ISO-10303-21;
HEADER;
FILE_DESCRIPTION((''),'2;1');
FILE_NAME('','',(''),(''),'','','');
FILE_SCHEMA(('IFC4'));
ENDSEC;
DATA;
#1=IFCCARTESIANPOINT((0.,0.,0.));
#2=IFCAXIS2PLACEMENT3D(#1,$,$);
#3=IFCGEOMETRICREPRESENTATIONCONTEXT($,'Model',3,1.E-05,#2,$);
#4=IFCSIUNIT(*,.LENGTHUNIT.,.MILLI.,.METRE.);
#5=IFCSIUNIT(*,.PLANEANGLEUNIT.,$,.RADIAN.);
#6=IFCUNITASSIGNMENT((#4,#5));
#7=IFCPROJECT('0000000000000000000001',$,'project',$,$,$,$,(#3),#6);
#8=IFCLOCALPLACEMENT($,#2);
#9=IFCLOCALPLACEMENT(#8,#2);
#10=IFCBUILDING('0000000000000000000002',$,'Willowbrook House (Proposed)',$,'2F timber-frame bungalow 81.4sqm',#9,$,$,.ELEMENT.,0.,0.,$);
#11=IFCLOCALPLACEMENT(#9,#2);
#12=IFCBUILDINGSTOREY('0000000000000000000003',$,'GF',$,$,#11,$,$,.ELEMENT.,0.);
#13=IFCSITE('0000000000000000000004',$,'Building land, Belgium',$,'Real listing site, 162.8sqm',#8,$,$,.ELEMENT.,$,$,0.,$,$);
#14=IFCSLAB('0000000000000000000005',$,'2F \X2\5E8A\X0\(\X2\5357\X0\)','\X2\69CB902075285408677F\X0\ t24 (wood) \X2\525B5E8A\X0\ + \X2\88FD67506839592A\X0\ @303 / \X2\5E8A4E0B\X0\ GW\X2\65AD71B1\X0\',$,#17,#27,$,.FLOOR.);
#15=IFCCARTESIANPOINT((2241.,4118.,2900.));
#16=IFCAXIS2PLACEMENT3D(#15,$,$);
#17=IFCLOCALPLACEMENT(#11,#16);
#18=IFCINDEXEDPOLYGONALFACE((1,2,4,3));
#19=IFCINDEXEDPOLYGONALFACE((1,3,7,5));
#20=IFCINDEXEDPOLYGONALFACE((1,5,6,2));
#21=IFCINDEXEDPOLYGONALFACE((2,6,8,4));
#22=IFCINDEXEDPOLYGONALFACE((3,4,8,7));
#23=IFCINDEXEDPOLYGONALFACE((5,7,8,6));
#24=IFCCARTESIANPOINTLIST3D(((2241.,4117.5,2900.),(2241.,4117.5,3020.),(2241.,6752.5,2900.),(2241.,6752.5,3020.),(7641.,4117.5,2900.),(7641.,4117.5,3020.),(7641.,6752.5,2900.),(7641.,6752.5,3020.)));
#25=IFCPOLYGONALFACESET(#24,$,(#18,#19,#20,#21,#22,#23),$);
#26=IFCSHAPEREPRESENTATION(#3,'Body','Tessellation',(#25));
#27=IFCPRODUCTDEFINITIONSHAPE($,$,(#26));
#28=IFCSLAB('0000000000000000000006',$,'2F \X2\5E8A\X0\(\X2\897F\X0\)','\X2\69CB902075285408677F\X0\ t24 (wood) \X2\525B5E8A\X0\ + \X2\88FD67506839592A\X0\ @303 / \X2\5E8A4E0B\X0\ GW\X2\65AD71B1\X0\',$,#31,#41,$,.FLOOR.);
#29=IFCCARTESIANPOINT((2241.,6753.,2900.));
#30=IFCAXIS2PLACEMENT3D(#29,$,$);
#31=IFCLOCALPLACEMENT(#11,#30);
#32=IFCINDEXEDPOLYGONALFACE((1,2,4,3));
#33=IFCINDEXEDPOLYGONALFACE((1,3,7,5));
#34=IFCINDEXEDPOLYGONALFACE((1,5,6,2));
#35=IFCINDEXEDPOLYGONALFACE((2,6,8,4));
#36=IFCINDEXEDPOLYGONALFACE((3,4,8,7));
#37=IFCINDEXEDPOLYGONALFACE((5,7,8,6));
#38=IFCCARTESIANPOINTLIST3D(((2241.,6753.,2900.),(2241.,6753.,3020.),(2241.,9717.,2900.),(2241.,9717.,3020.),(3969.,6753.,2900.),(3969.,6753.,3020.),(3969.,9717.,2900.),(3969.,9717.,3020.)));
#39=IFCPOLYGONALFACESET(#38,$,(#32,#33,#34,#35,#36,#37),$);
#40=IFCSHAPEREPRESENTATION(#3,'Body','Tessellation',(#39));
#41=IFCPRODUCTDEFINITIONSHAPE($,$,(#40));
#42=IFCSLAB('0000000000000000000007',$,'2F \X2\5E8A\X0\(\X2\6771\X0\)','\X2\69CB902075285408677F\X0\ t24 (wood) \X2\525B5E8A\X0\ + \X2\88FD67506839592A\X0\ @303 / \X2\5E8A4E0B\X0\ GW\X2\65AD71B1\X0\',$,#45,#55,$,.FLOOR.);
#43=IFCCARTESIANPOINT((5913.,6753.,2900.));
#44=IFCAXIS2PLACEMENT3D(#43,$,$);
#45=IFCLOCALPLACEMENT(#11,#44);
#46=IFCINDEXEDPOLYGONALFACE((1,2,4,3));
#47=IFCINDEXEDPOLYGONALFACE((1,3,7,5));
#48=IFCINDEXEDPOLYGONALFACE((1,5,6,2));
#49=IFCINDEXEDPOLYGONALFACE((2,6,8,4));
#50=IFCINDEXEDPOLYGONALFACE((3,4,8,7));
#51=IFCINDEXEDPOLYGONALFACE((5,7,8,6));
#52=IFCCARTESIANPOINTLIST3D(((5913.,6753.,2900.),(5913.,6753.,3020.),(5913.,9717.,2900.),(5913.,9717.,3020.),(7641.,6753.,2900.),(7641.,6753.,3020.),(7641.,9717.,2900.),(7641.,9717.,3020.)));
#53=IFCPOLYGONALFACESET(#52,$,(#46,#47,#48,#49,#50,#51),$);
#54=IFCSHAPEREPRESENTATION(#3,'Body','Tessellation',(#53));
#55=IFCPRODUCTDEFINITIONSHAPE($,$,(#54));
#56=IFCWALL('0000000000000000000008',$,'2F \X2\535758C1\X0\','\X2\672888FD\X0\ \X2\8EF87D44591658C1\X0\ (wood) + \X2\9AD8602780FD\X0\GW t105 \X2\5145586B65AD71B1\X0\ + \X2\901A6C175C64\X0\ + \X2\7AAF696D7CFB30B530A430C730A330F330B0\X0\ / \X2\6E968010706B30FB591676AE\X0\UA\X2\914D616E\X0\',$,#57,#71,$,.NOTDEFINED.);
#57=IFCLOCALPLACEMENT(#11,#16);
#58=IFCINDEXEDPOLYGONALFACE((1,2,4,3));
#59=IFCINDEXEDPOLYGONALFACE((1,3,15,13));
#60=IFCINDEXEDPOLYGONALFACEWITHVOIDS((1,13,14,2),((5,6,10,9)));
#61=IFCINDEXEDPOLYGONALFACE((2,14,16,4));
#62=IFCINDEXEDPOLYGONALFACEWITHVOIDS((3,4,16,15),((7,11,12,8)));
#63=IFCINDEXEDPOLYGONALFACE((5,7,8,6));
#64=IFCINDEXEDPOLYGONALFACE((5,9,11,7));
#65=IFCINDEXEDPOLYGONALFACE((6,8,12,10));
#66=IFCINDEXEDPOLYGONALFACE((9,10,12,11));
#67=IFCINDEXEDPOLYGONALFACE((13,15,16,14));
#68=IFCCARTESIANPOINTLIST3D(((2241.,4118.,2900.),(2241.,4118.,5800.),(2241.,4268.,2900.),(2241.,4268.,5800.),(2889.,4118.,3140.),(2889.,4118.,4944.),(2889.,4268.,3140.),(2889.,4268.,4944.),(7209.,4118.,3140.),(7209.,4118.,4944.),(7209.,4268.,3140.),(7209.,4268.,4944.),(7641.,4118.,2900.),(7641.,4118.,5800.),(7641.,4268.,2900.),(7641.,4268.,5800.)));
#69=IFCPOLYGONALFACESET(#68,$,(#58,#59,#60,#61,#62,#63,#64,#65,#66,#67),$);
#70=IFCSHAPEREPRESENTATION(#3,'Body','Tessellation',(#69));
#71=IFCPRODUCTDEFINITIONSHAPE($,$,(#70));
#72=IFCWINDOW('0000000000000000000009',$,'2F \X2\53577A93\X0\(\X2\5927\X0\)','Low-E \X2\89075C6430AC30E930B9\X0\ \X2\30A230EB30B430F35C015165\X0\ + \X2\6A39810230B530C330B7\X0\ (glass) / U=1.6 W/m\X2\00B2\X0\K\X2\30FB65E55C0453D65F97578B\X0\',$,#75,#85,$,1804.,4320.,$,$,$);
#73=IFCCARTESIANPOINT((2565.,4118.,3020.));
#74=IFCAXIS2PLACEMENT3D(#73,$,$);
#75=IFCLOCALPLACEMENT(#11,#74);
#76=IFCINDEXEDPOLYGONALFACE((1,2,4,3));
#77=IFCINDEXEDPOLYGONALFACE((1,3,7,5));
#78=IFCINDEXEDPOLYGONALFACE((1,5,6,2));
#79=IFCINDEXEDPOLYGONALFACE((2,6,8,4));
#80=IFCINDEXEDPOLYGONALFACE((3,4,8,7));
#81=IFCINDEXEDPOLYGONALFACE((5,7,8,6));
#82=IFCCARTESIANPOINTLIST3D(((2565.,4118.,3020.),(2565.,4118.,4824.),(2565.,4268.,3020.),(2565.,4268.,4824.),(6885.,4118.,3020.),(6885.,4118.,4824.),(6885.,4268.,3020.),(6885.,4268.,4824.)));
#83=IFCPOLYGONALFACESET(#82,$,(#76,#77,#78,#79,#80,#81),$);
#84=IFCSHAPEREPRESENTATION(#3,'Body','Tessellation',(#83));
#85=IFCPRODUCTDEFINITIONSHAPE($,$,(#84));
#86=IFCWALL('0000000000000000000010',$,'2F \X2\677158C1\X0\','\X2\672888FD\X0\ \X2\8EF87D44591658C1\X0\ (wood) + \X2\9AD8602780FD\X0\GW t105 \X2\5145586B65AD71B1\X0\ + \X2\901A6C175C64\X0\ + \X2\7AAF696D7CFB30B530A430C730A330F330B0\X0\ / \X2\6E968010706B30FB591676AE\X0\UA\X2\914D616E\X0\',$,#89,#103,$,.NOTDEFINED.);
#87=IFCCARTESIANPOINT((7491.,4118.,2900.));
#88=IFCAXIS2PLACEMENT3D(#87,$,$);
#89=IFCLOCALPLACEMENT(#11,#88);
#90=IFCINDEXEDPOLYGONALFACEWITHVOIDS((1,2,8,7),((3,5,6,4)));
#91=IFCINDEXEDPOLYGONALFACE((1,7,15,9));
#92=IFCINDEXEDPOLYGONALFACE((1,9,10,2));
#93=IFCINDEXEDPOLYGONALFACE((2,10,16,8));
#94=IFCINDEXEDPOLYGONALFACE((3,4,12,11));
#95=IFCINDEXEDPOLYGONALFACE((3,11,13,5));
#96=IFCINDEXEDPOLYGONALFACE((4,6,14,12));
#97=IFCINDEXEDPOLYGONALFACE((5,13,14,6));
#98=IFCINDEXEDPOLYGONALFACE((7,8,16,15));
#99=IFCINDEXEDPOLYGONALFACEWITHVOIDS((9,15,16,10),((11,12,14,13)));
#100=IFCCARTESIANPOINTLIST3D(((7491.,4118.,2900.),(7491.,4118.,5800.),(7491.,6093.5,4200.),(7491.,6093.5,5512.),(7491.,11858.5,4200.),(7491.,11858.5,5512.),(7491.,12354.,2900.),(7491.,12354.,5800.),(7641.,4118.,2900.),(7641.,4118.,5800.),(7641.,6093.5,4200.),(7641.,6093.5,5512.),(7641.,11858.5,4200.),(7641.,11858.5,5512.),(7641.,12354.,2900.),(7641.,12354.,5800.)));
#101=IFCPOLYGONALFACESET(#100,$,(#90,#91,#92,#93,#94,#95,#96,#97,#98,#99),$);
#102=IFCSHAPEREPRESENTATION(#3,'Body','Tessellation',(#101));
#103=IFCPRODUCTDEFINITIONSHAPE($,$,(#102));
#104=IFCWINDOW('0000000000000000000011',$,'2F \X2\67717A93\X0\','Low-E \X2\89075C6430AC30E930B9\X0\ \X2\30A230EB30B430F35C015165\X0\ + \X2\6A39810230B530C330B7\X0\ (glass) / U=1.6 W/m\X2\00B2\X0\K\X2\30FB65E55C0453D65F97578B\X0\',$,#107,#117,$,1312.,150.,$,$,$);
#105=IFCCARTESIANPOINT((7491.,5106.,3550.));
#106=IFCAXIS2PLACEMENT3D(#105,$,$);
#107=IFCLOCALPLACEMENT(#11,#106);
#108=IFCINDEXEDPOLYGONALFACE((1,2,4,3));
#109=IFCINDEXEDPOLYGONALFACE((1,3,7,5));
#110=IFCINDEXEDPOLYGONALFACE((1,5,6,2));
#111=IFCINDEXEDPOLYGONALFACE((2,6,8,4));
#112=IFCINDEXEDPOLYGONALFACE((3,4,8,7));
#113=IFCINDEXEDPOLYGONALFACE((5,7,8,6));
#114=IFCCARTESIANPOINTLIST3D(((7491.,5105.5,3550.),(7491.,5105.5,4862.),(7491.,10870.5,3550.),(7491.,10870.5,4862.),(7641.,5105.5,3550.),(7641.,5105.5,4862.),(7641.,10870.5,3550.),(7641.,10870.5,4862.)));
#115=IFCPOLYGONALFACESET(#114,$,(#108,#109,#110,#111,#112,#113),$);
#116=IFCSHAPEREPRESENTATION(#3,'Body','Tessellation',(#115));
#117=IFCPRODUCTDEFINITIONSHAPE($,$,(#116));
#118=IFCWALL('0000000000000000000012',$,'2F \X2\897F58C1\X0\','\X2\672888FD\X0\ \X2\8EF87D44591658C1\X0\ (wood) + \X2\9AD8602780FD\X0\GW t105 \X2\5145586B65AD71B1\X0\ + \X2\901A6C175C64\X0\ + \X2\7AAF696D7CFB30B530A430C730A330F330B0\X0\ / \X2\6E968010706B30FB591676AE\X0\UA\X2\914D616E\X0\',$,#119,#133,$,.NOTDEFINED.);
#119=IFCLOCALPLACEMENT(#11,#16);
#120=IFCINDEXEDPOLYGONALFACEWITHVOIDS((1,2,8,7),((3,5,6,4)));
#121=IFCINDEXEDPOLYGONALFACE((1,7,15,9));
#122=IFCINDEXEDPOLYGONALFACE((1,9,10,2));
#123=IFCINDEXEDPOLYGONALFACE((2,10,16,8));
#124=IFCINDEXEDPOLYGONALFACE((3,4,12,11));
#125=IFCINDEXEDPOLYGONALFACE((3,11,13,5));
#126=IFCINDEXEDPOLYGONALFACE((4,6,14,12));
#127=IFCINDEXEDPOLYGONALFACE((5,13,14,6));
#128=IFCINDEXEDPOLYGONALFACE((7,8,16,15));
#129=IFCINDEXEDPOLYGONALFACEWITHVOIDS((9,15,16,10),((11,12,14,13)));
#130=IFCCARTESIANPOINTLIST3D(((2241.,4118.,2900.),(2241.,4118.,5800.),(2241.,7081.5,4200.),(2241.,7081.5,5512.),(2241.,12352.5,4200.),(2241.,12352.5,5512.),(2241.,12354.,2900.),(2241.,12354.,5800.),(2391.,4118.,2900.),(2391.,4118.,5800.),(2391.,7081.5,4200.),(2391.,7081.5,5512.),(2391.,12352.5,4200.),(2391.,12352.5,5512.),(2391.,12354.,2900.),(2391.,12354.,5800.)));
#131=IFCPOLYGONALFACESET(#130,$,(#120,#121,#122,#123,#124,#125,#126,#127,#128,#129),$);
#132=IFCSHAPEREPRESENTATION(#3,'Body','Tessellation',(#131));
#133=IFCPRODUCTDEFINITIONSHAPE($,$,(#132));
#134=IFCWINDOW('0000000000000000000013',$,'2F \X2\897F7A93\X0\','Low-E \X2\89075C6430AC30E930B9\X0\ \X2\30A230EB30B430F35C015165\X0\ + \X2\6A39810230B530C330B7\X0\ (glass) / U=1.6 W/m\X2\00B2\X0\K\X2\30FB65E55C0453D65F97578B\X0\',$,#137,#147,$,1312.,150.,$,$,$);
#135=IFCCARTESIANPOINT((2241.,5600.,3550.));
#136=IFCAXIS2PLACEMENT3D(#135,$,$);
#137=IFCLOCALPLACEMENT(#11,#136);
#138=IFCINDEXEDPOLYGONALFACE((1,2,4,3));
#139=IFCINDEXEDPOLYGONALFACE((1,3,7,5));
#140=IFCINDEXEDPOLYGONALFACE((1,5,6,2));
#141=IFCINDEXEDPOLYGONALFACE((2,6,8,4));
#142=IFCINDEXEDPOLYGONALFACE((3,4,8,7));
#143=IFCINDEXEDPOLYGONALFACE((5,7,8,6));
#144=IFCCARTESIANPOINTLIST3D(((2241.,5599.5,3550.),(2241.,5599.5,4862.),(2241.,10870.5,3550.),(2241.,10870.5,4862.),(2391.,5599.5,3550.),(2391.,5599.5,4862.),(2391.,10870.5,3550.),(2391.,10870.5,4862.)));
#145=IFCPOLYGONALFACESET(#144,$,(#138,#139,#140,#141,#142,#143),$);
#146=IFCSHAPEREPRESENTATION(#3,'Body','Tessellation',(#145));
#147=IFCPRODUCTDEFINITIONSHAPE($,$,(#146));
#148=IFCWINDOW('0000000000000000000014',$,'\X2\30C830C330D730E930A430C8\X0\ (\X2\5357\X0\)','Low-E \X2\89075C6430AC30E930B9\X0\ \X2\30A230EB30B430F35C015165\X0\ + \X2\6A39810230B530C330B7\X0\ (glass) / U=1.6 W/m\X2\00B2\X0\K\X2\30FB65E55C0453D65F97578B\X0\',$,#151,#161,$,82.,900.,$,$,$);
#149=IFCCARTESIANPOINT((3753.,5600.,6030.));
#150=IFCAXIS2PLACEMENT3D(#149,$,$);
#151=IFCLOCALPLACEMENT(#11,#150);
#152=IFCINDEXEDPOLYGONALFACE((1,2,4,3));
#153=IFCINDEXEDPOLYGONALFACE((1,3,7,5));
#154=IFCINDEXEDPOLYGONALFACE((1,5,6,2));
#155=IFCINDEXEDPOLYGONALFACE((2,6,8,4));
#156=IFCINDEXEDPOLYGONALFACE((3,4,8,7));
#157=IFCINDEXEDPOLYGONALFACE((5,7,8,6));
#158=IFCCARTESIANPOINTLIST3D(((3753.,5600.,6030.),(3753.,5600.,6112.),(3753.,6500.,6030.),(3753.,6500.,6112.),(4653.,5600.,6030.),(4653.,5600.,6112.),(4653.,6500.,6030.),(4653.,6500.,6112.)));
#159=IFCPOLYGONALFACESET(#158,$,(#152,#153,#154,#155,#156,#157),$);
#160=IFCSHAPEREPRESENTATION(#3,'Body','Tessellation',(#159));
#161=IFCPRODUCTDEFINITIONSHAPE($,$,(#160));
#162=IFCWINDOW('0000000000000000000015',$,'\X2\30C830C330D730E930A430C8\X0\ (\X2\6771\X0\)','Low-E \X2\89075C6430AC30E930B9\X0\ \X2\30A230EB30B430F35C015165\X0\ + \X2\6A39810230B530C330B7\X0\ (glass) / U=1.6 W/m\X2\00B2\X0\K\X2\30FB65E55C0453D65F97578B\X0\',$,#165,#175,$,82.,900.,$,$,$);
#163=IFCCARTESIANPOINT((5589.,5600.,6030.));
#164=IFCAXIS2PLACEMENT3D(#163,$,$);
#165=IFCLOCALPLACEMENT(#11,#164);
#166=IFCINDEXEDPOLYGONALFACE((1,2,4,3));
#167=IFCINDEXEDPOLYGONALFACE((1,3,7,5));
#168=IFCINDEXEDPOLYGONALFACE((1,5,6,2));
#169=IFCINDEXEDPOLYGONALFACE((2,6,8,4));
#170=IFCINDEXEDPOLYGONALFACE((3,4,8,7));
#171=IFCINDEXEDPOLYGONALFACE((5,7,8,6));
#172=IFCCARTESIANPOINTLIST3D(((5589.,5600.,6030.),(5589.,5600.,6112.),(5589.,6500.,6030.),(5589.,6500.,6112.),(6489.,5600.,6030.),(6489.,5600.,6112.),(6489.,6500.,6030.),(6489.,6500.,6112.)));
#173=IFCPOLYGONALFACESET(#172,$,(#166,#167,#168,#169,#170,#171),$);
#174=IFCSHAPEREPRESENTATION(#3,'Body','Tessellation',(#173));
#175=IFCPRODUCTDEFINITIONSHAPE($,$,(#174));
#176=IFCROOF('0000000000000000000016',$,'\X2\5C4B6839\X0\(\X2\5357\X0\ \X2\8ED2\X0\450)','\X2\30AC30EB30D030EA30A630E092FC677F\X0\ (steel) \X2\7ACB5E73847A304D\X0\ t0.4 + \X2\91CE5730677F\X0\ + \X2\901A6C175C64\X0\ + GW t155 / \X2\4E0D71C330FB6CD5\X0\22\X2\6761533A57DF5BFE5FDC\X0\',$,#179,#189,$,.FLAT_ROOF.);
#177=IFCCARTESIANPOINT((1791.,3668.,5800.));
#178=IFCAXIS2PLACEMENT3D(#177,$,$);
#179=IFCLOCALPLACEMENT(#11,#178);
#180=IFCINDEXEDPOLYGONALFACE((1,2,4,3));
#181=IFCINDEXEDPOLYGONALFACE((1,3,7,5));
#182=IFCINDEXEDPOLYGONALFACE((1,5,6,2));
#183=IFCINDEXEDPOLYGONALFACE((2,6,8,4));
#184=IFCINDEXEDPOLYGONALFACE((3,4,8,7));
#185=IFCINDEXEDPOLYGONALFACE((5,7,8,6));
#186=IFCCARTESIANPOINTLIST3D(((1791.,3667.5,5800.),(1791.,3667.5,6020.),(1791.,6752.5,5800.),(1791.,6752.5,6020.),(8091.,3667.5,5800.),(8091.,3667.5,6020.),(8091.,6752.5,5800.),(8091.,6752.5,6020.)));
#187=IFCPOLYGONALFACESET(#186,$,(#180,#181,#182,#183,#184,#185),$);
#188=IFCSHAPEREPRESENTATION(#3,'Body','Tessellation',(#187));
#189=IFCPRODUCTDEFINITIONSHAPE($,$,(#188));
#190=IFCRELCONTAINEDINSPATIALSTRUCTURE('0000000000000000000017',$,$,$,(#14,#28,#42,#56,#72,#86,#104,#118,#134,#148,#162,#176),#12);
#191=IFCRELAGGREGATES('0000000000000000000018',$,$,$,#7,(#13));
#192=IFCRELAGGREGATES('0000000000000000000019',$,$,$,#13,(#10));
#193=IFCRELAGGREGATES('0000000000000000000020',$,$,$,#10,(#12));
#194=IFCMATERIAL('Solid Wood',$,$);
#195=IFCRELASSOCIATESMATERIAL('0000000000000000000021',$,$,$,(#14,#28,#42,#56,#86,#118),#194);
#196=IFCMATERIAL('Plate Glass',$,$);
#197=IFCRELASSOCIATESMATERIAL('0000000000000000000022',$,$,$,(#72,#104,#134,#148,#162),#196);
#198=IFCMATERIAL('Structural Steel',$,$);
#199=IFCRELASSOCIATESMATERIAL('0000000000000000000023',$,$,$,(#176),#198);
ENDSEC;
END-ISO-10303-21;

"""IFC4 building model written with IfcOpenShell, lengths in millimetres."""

from ifc_helpers import new_model, si_unit, frame, frame_2d, origin, place, context, project, spatial, rectangle, extrude, material, element, fill, save


model = new_model("IFC4")

# Units and contexts
model_context = context("Model", 3, precision=1e-05, world=origin())
ifc_project = project(units=[si_unit("LENGTHUNIT", "METRE", prefix="MILLI"), si_unit("PLANEANGLEUNIT", "RADIAN")], contexts=[model_context])

# Site, building, storey
site_placement = place(None, origin())
site = spatial("IfcSite", under=ifc_project, at=site_placement, Name="Building land, Belgium", ObjectType="Real listing site, 162.8sqm", CompositionType="ELEMENT", RefElevation=0.0)
building_placement = place(site_placement, origin())
building = spatial("IfcBuilding", under=site, at=building_placement, Name="Willowbrook House (Proposed)", ObjectType="2F timber-frame bungalow 81.4sqm", CompositionType="ELEMENT", ElevationOfRefHeight=0.0, ElevationOfTerrain=0.0)
storey_placement = place(building_placement, origin())
storey = spatial("IfcBuildingStorey", under=building, at=storey_placement, Name="GF", CompositionType="ELEMENT", Elevation=0.0)

# Slabs
ifc_material_1 = material(Name="Solid Wood")
slab_1_placement = place(storey_placement, frame((2241.0, 4118.0, 2900.0)))
element("IfcSlab", 1, at=slab_1_placement, inside=storey, material=ifc_material_1, Name="2F 床(南)", Description="構造用合板 t24 (wood) 剛床 + 製材根太 @303 / 床下 GW断熱", PredefinedType="FLOOR", context=model_context, shape_type="SweptSolid", body=[
    extrude(rectangle(XDim=5400.0, YDim=2635.0, at=frame_2d((2700.0, 1317.0))), frame((2241.0, 4118.0, 2900.0)), (0.0, 0.0, 1.0), 120.0),
])
slab_2_placement = place(storey_placement, frame((2241.0, 6753.0, 2900.0)))
element("IfcSlab", 2, at=slab_2_placement, inside=storey, material=ifc_material_1, Name="2F 床(西)", Description="構造用合板 t24 (wood) 剛床 + 製材根太 @303 / 床下 GW断熱", PredefinedType="FLOOR", context=model_context, shape_type="SweptSolid", body=[
    extrude(rectangle(XDim=1728.0, YDim=2964.0, at=frame_2d((864.0, 1482.0))), frame((2241.0, 6753.0, 2900.0)), (0.0, 0.0, 1.0), 120.0),
])
slab_3_placement = place(storey_placement, frame((5913.0, 6753.0, 2900.0)))
element("IfcSlab", 3, at=slab_3_placement, inside=storey, material=ifc_material_1, Name="2F 床(東)", Description="構造用合板 t24 (wood) 剛床 + 製材根太 @303 / 床下 GW断熱", PredefinedType="FLOOR", context=model_context, shape_type="SweptSolid", body=[
    extrude(rectangle(XDim=1728.0, YDim=2964.0, at=frame_2d((864.0, 1482.0))), frame((5913.0, 6753.0, 2900.0)), (0.0, 0.0, 1.0), 120.0),
])

# Walls, openings, windows
wall_1_placement = place(storey_placement, frame((2241.0, 4118.0, 2900.0)))
wall_1 = element("IfcWall", 4, at=wall_1_placement, inside=storey, material=ifc_material_1, Name="2F 南壁", Description="木製 軸組外壁 (wood) + 高性能GW t105 充填断熱 + 通気層 + 窯業系サイディング / 準耐火・外皮UA配慮", PredefinedType="NOTDEFINED", context=model_context, shape_type="SweptSolid", body=[
    extrude(rectangle(XDim=5400.0, YDim=150.0, at=frame_2d((2700.0, 75.0))), frame((2241.0, 4118.0, 2900.0)), (0.0, 0.0, 1.0), 2900.0),
])
opening_1_placement = place(storey_placement, frame((2565.0, 4118.0, 3020.0)))
opening_1 = element("IfcOpeningElement", 5, at=opening_1_placement, cuts=wall_1, PredefinedType="NOTDEFINED", context=model_context, shape_type="SweptSolid", body=[
    extrude(rectangle(XDim=4320.0, YDim=150.0, at=frame_2d((2160.0, 75.0))), frame((2565.0, 4118.0, 3020.0)), (0.0, 0.0, 1.0), 1804.0),
])
ifc_material_2 = material(Name="Plate Glass")
window_1_placement = place(storey_placement, frame((2565.0, 4118.0, 3020.0)))
window_1 = element("IfcWindow", 6, at=window_1_placement, inside=storey, material=ifc_material_2, Name="2F 南窓(大)", Description="Low-E 複層ガラス アルゴン封入 + 樹脂サッシ (glass) / U=1.6 W/m²K・日射取得型", OverallHeight=1804.0, OverallWidth=4320.0, context=model_context, shape_type="SweptSolid", body=[
    extrude(rectangle(XDim=4320.0, YDim=150.0, at=frame_2d((2160.0, 75.0))), frame((2565.0, 4118.0, 3020.0)), (0.0, 0.0, 1.0), 1804.0),
])
fill(opening_1, window_1)
wall_2_placement = place(storey_placement, frame((7491.0, 4118.0, 2900.0)))
wall_2 = element("IfcWall", 7, at=wall_2_placement, inside=storey, material=ifc_material_1, Name="2F 東壁", Description="木製 軸組外壁 (wood) + 高性能GW t105 充填断熱 + 通気層 + 窯業系サイディング / 準耐火・外皮UA配慮", PredefinedType="NOTDEFINED", context=model_context, shape_type="SweptSolid", body=[
    extrude(rectangle(XDim=150.0, YDim=8236.0, at=frame_2d((75.0, 4118.0))), frame((7491.0, 4118.0, 2900.0)), (0.0, 0.0, 1.0), 2900.0),
])
opening_2_placement = place(storey_placement, frame((7491.0, 5106.0, 3550.0)))
opening_2 = element("IfcOpeningElement", 8, at=opening_2_placement, cuts=wall_2, PredefinedType="NOTDEFINED", context=model_context, shape_type="SweptSolid", body=[
    extrude(rectangle(XDim=150.0, YDim=5765.0, at=frame_2d((75.0, 2882.0))), frame((7491.0, 5106.0, 3550.0)), (0.0, 0.0, 1.0), 1312.0),
])
window_2_placement = place(storey_placement, frame((7491.0, 5106.0, 3550.0)))
window_2 = element("IfcWindow", 9, at=window_2_placement, inside=storey, material=ifc_material_2, Name="2F 東窓", Description="Low-E 複層ガラス アルゴン封入 + 樹脂サッシ (glass) / U=1.6 W/m²K・日射取得型", OverallHeight=1312.0, OverallWidth=150.0, context=model_context, shape_type="SweptSolid", body=[
    extrude(rectangle(XDim=150.0, YDim=5765.0, at=frame_2d((75.0, 2882.0))), frame((7491.0, 5106.0, 3550.0)), (0.0, 0.0, 1.0), 1312.0),
])
fill(opening_2, window_2)
wall_3_placement = place(storey_placement, frame((2241.0, 4118.0, 2900.0)))
wall_3 = element("IfcWall", 10, at=wall_3_placement, inside=storey, material=ifc_material_1, Name="2F 西壁", Description="木製 軸組外壁 (wood) + 高性能GW t105 充填断熱 + 通気層 + 窯業系サイディング / 準耐火・外皮UA配慮", PredefinedType="NOTDEFINED", context=model_context, shape_type="SweptSolid", body=[
    extrude(rectangle(XDim=150.0, YDim=8236.0, at=frame_2d((75.0, 4118.0))), frame((2241.0, 4118.0, 2900.0)), (0.0, 0.0, 1.0), 2900.0),
])
opening_3_placement = place(storey_placement, frame((2241.0, 5600.0, 3550.0)))
opening_3 = element("IfcOpeningElement", 11, at=opening_3_placement, cuts=wall_3, PredefinedType="NOTDEFINED", context=model_context, shape_type="SweptSolid", body=[
    extrude(rectangle(XDim=150.0, YDim=5271.0, at=frame_2d((75.0, 2635.0))), frame((2241.0, 5600.0, 3550.0)), (0.0, 0.0, 1.0), 1312.0),
])
window_3_placement = place(storey_placement, frame((2241.0, 5600.0, 3550.0)))
window_3 = element("IfcWindow", 12, at=window_3_placement, inside=storey, material=ifc_material_2, Name="2F 西窓", Description="Low-E 複層ガラス アルゴン封入 + 樹脂サッシ (glass) / U=1.6 W/m²K・日射取得型", OverallHeight=1312.0, OverallWidth=150.0, context=model_context, shape_type="SweptSolid", body=[
    extrude(rectangle(XDim=150.0, YDim=5271.0, at=frame_2d((75.0, 2635.0))), frame((2241.0, 5600.0, 3550.0)), (0.0, 0.0, 1.0), 1312.0),
])
fill(opening_3, window_3)

# Windows
window_4_placement = place(storey_placement, frame((3753.0, 5600.0, 6030.0)))
element("IfcWindow", 13, at=window_4_placement, inside=storey, material=ifc_material_2, Name="トップライト (南)", Description="Low-E 複層ガラス アルゴン封入 + 樹脂サッシ (glass) / U=1.6 W/m²K・日射取得型", OverallHeight=82.0, OverallWidth=900.0, context=model_context, shape_type="SweptSolid", body=[
    extrude(rectangle(XDim=900.0, YDim=900.0, at=frame_2d((450.0, 450.0))), frame((3753.0, 5600.0, 6030.0)), (0.0, 0.0, 1.0), 82.0),
])
window_5_placement = place(storey_placement, frame((5589.0, 5600.0, 6030.0)))
element("IfcWindow", 14, at=window_5_placement, inside=storey, material=ifc_material_2, Name="トップライト (東)", Description="Low-E 複層ガラス アルゴン封入 + 樹脂サッシ (glass) / U=1.6 W/m²K・日射取得型", OverallHeight=82.0, OverallWidth=900.0, context=model_context, shape_type="SweptSolid", body=[
    extrude(rectangle(XDim=900.0, YDim=900.0, at=frame_2d((450.0, 450.0))), frame((5589.0, 5600.0, 6030.0)), (0.0, 0.0, 1.0), 82.0),
])

# Roof
ifc_material_3 = material(Name="Structural Steel")
roof_1_placement = place(storey_placement, frame((1791.0, 3668.0, 5800.0)))
element("IfcRoof", 15, at=roof_1_placement, inside=storey, material=ifc_material_3, Name="屋根(南 軒450)", Description="ガルバリウム鋼板 (steel) 立平葺き t0.4 + 野地板 + 通気層 + GW t155 / 不燃・法22条区域対応", PredefinedType="FLAT_ROOF", context=model_context, shape_type="SweptSolid", body=[
    extrude(rectangle(XDim=6300.0, YDim=3085.0, at=frame_2d((3150.0, 1542.0))), frame((1791.0, 3668.0, 5800.0)), (0.0, 0.0, 1.0), 220.0),
])

save(model, "model.ifc")
